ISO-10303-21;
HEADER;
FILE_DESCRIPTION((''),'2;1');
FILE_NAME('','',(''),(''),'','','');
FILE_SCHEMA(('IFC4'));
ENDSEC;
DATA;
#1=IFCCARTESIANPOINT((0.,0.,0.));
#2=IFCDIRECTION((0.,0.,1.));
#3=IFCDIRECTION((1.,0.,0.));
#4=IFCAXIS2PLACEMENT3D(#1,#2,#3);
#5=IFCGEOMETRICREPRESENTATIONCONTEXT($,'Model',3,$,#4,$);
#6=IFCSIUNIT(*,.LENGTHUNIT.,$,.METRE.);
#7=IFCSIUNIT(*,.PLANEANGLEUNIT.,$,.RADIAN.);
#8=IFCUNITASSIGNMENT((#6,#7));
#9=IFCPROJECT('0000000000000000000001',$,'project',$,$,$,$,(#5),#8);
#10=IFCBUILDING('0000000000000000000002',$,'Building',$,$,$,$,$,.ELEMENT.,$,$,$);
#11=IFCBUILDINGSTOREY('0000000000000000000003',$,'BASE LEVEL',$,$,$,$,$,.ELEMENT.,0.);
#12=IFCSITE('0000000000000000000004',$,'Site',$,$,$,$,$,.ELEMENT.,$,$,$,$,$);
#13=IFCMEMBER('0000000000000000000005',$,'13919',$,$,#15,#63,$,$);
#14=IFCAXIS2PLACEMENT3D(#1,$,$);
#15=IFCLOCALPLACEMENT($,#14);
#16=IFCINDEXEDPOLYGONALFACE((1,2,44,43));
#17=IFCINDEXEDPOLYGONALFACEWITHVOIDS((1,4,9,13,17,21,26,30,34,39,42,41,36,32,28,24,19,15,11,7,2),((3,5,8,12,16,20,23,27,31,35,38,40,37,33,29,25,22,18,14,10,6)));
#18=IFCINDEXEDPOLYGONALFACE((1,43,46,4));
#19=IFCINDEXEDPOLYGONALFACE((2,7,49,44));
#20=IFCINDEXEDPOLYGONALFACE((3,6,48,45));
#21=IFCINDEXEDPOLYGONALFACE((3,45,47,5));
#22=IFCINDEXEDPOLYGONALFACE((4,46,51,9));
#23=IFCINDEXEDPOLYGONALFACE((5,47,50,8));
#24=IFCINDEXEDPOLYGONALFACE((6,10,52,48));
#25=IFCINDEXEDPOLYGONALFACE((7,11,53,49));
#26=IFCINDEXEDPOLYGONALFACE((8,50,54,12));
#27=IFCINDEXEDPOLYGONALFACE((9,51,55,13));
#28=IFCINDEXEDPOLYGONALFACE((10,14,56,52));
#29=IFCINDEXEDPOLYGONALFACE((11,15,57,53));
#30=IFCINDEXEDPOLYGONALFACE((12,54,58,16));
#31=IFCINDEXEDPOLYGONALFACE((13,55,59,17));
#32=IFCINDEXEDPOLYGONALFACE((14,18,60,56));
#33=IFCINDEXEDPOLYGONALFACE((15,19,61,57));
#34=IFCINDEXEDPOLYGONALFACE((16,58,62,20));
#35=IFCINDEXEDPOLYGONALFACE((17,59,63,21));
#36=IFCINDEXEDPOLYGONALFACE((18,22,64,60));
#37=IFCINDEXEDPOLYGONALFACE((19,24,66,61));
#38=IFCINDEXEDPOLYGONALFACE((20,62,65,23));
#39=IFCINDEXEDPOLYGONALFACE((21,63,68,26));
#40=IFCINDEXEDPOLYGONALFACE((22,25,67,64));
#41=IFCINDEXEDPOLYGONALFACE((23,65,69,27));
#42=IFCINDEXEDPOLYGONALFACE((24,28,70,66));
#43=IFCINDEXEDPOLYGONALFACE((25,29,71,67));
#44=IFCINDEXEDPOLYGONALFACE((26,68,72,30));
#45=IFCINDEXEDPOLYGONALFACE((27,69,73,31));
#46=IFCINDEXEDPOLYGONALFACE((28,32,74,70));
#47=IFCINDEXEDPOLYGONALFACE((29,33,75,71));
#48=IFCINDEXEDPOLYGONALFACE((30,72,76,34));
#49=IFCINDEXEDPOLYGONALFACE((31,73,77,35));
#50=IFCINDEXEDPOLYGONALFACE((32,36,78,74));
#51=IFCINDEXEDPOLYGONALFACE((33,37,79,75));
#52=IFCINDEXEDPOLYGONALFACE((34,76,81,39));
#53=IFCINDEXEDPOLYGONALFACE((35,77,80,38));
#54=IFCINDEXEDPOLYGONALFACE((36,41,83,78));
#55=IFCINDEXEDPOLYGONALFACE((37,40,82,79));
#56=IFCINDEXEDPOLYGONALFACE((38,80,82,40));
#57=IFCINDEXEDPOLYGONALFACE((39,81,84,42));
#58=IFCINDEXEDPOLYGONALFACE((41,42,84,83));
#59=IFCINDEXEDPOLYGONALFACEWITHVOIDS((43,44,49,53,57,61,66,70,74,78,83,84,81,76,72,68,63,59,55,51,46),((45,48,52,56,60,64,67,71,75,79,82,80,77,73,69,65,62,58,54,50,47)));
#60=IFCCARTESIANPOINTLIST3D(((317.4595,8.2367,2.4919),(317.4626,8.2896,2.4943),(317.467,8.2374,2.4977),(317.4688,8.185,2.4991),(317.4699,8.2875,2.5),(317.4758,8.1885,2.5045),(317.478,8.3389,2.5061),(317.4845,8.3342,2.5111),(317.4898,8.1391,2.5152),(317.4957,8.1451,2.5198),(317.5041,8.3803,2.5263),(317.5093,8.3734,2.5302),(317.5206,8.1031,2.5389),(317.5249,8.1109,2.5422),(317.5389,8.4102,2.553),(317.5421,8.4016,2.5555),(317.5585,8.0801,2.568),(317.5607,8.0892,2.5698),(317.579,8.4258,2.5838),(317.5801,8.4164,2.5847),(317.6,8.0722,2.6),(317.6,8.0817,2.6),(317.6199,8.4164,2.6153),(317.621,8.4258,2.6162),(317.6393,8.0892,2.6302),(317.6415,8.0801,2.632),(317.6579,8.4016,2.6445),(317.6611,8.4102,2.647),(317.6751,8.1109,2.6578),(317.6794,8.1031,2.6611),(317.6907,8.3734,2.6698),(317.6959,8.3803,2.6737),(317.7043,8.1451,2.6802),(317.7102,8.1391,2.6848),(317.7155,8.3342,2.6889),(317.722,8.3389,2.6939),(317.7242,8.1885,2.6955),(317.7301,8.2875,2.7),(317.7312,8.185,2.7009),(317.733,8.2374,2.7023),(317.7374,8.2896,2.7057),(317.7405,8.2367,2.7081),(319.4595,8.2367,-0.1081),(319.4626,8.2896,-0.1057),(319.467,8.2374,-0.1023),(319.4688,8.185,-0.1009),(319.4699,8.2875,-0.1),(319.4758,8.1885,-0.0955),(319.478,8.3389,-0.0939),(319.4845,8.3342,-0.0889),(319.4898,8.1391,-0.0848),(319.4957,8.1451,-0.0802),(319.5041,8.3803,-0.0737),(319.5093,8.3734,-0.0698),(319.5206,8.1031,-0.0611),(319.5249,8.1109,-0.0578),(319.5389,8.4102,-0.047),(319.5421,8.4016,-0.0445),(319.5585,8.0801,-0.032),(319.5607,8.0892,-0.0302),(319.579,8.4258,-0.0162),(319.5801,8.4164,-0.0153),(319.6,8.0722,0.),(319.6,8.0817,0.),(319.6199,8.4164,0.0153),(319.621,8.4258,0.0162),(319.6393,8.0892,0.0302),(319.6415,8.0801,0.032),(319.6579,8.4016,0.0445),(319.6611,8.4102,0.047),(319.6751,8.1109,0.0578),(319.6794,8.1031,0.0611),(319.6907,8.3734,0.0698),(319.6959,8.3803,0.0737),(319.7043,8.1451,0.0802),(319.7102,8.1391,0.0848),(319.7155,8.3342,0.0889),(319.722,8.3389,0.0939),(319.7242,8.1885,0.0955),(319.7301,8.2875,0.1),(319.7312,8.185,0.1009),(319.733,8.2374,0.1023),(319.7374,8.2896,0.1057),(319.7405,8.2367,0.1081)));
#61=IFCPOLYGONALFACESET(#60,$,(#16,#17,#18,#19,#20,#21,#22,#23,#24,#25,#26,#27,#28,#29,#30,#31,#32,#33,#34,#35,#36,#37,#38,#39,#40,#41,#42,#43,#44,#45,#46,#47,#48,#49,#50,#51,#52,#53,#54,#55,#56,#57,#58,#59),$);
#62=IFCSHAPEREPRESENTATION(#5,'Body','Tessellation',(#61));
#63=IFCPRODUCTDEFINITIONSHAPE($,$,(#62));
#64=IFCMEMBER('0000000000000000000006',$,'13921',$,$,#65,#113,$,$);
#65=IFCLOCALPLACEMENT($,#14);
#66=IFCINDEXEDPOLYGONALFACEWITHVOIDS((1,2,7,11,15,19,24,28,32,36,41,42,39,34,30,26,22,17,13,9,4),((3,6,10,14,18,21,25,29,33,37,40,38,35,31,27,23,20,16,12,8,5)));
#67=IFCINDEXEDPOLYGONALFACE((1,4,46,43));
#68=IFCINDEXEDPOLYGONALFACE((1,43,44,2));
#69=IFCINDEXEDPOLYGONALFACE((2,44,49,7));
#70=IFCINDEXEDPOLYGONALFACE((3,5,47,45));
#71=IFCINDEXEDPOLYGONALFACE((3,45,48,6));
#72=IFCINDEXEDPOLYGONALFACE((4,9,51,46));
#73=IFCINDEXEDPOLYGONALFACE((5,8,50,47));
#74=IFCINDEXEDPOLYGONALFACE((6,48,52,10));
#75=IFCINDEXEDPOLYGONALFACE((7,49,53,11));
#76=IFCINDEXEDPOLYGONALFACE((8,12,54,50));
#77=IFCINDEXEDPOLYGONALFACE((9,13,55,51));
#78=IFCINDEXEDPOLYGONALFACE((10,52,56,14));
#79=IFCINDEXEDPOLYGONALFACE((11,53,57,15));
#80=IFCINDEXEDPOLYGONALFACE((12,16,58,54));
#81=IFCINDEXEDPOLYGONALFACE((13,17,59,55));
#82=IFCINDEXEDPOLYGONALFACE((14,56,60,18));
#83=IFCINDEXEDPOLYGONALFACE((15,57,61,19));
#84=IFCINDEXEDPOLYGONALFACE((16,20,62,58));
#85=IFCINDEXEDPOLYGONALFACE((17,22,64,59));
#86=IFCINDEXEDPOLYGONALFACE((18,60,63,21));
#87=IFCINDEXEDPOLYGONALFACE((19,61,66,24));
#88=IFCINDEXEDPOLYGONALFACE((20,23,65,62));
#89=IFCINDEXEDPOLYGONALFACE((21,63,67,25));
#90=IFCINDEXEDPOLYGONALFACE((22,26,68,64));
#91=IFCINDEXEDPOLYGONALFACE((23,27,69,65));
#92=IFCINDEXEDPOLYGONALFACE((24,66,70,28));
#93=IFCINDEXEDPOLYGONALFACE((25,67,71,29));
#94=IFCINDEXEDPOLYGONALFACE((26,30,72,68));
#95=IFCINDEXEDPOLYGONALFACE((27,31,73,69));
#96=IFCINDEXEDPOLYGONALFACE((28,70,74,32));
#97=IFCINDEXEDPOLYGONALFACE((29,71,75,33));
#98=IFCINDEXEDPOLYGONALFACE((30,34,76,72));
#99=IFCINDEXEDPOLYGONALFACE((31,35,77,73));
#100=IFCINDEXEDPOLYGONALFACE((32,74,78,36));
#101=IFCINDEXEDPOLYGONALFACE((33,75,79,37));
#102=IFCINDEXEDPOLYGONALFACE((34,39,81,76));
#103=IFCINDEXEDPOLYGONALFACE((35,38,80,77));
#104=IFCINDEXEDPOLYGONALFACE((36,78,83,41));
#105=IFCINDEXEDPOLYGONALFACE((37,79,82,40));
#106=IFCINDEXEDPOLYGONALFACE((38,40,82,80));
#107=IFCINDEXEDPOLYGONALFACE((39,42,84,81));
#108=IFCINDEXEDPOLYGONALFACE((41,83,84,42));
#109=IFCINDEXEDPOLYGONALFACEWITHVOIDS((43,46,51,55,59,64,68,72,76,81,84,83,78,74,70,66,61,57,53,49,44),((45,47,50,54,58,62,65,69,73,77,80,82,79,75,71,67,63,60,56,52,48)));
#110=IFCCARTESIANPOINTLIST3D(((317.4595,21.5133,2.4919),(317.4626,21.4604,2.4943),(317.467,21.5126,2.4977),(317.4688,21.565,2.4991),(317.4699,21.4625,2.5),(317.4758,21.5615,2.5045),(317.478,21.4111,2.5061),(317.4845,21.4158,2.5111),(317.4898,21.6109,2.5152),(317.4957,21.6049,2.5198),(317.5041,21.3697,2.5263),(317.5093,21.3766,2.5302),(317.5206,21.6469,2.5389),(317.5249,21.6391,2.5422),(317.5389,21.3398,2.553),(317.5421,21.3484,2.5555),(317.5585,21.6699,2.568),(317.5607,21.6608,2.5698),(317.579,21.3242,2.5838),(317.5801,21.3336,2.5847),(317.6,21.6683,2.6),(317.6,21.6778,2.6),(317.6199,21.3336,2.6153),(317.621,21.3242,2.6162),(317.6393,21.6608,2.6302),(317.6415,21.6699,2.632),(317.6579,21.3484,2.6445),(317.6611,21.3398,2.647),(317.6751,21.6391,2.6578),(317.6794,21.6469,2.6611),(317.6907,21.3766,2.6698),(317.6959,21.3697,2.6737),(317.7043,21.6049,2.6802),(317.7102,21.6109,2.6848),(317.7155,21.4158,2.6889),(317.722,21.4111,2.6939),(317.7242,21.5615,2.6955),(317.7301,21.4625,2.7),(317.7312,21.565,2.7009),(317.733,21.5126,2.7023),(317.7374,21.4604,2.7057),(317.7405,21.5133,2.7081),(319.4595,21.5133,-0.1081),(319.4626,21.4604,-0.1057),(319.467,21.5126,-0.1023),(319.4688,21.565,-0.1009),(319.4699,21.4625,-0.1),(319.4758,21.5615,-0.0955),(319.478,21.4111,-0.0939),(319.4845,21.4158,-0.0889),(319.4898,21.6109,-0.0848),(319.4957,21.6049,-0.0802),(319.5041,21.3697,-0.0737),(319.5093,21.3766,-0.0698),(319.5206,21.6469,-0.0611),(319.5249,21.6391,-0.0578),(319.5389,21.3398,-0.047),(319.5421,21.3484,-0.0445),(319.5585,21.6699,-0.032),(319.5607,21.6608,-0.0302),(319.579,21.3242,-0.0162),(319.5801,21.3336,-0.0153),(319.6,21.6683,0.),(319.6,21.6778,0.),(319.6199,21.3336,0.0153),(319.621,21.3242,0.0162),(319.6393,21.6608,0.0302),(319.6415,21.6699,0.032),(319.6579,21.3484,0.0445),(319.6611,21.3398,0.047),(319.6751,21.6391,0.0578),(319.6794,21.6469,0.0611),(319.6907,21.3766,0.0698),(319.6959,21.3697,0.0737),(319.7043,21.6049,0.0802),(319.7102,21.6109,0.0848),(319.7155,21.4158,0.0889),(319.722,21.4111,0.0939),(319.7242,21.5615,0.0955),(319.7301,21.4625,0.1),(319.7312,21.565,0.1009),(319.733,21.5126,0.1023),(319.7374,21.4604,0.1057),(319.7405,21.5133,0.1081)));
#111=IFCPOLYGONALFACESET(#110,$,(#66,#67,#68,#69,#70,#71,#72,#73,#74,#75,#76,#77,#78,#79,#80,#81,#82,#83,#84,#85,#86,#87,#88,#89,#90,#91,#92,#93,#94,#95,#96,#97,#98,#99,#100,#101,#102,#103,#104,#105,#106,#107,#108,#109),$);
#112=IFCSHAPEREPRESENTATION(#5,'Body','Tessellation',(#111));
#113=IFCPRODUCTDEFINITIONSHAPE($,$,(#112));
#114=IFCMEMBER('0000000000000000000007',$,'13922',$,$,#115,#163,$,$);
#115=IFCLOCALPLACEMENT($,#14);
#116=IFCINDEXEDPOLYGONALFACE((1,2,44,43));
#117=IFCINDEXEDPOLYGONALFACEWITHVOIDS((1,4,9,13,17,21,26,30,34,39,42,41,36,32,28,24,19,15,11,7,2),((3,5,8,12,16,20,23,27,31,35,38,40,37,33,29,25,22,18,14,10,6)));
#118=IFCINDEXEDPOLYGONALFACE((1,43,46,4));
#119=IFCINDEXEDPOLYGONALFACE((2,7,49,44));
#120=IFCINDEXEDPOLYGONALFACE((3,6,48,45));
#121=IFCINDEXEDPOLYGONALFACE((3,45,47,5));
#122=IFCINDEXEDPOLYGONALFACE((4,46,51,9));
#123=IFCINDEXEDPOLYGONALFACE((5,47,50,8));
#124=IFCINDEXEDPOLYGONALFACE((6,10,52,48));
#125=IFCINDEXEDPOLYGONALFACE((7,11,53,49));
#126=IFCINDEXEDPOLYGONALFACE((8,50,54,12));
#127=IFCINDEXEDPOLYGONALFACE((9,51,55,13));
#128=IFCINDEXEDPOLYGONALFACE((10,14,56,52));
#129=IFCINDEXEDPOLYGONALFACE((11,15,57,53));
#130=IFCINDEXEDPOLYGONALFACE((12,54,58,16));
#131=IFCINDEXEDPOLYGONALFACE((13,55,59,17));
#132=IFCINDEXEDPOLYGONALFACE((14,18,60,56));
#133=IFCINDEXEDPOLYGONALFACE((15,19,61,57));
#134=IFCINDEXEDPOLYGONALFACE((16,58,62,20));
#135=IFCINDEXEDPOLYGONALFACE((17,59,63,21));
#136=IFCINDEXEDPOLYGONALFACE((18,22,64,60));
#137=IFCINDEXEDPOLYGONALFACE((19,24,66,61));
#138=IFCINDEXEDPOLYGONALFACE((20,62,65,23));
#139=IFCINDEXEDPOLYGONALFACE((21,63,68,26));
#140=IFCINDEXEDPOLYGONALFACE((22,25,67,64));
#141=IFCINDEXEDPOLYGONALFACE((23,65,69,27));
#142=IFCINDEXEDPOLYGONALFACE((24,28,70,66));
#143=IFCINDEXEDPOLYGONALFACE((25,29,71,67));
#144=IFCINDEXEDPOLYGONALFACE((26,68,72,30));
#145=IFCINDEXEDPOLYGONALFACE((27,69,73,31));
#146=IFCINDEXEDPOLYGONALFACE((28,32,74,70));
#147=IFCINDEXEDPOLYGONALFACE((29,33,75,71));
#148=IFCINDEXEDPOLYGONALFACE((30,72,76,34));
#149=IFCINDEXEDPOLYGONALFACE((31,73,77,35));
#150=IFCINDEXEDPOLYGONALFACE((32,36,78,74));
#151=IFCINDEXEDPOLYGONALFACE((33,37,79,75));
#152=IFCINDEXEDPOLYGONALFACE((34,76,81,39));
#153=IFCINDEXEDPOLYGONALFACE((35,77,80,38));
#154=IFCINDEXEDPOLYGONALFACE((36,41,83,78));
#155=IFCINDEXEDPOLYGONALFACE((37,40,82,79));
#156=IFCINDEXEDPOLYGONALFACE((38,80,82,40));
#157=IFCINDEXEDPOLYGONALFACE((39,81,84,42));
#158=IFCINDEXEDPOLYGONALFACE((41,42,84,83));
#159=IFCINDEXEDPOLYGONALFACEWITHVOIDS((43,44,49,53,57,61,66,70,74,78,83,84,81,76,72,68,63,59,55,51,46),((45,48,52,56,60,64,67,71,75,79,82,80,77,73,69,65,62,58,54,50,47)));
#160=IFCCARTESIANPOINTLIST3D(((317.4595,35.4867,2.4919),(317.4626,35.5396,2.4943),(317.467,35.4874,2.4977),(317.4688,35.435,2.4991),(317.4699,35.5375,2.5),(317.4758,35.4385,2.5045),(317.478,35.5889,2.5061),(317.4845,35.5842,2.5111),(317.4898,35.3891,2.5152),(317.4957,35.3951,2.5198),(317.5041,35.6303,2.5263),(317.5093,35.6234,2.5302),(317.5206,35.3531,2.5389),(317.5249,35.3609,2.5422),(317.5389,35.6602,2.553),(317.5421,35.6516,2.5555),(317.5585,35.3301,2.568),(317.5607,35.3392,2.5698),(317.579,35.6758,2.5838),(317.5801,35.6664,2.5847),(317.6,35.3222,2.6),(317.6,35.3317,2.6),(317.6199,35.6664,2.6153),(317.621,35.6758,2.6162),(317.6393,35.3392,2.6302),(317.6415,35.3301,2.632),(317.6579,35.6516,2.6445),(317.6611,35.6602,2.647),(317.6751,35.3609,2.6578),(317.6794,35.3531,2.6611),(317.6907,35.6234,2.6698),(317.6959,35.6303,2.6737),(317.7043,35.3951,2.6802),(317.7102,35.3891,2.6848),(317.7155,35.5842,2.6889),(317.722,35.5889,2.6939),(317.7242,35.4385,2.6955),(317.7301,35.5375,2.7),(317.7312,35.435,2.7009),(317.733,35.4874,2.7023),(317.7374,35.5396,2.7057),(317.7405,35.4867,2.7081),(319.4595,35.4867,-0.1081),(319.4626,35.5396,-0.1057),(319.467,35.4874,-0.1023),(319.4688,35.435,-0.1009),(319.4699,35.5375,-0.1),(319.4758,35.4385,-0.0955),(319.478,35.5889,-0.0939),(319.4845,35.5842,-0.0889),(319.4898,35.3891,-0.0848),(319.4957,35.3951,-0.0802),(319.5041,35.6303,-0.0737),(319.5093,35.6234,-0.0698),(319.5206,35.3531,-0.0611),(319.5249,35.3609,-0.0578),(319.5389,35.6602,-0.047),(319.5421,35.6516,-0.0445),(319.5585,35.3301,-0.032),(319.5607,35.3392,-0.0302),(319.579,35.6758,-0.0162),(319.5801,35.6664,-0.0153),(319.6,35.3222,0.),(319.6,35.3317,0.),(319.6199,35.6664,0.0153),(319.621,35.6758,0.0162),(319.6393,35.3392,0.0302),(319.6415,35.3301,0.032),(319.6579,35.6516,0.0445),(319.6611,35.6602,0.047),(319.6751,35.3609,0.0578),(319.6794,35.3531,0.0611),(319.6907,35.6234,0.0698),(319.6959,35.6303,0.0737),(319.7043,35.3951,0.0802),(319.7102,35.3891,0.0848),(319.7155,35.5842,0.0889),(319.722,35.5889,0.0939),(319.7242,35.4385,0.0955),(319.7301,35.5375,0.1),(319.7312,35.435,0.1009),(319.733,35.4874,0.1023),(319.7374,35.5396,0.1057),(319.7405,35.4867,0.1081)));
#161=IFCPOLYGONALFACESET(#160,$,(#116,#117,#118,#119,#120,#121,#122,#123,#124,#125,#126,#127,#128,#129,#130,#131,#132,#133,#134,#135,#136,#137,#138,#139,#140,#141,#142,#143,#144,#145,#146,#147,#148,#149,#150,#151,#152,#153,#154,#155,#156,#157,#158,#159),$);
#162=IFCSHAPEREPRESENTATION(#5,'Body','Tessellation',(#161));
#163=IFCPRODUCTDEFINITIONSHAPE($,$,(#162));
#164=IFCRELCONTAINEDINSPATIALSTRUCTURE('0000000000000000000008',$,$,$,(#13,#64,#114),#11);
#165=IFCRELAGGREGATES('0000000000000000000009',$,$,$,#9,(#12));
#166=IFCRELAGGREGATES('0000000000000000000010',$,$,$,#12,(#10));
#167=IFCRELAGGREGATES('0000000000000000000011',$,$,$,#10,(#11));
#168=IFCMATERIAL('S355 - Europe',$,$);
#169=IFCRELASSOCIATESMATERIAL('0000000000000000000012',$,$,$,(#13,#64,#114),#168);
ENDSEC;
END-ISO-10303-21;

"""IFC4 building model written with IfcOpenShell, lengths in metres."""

from ifc_helpers import new_model, si_unit, frame, origin_with_axes, origin_2d_with_axis, place, context, project, spatial, hollow_circle, extrude, material, material_profile, profile_set, profile_usage, element, save


model = new_model("IFC4")

# Units and contexts
model_context = context("Model", 3, world=origin_with_axes())
ifc_project = project(units=[si_unit("LENGTHUNIT", "METRE"), si_unit("PLANEANGLEUNIT", "RADIAN")], contexts=[model_context])

# Site, building, storey
site = spatial("IfcSite", under=ifc_project, Name="Site", CompositionType="ELEMENT")
building = spatial("IfcBuilding", under=site, Name="Building", CompositionType="ELEMENT")
storey = spatial("IfcBuildingStorey", under=building, Name="BASE LEVEL", CompositionType="ELEMENT", Elevation=0.0)

# Shared definitions
ifc_material = material(Name="S355 - Europe")

# Members
ifc_material_profile_1 = material_profile(ifc_material, hollow_circle(Radius=0.1778, WallThickness=0.0095, at=origin_2d_with_axis()))
ifc_profile_set_1 = profile_set([ifc_material_profile_1])
ifc_profile_usage_1 = profile_usage(ifc_profile_set_1, cardinal=10)
member_1_placement = place(None, frame((319.6, 8.25, 0.0), z_axis=(-0.609711, 0.0, 0.792624), x_axis=(0.0, -1.0, 0.0)))
element("IfcMember", 1, at=member_1_placement, inside=storey, material=ifc_profile_usage_1, Name="13919", context=model_context, shape_type="SweptSolid", body=[
    extrude(hollow_circle(Radius=0.1778, WallThickness=0.0095, at=origin_2d_with_axis()), origin_with_axes(), (0.0, 0.0, 1.0), 3.2802),
])
ifc_material_profile_2 = material_profile(ifc_material, hollow_circle(Radius=0.1778, WallThickness=0.0095, at=origin_2d_with_axis()))
ifc_profile_set_2 = profile_set([ifc_material_profile_2])
ifc_profile_usage_2 = profile_usage(ifc_profile_set_2, cardinal=10)
member_2_placement = place(None, frame((317.6, 21.5, 2.6), z_axis=(0.609711, 0.0, -0.792624), x_axis=(0.0, 1.0, 0.0)))
element("IfcMember", 2, at=member_2_placement, inside=storey, material=ifc_profile_usage_2, Name="13921", context=model_context, shape_type="SweptSolid", body=[
    extrude(hollow_circle(Radius=0.1778, WallThickness=0.0095, at=origin_2d_with_axis()), origin_with_axes(), (0.0, 0.0, 1.0), 3.2802),
])
ifc_material_profile_3 = material_profile(ifc_material, hollow_circle(Radius=0.1778, WallThickness=0.0095, at=origin_2d_with_axis()))
ifc_profile_set_3 = profile_set([ifc_material_profile_3])
ifc_profile_usage_3 = profile_usage(ifc_profile_set_3, cardinal=10)
member_3_placement = place(None, frame((319.6, 35.5, 0.0), z_axis=(-0.609711, 0.0, 0.792624), x_axis=(0.0, -1.0, 0.0)))
element("IfcMember", 3, at=member_3_placement, inside=storey, material=ifc_profile_usage_3, Name="13922", context=model_context, shape_type="SweptSolid", body=[
    extrude(hollow_circle(Radius=0.1778, WallThickness=0.0095, at=origin_2d_with_axis()), origin_with_axes(), (0.0, 0.0, 1.0), 3.2802),
])

save(model, "model.ifc")
